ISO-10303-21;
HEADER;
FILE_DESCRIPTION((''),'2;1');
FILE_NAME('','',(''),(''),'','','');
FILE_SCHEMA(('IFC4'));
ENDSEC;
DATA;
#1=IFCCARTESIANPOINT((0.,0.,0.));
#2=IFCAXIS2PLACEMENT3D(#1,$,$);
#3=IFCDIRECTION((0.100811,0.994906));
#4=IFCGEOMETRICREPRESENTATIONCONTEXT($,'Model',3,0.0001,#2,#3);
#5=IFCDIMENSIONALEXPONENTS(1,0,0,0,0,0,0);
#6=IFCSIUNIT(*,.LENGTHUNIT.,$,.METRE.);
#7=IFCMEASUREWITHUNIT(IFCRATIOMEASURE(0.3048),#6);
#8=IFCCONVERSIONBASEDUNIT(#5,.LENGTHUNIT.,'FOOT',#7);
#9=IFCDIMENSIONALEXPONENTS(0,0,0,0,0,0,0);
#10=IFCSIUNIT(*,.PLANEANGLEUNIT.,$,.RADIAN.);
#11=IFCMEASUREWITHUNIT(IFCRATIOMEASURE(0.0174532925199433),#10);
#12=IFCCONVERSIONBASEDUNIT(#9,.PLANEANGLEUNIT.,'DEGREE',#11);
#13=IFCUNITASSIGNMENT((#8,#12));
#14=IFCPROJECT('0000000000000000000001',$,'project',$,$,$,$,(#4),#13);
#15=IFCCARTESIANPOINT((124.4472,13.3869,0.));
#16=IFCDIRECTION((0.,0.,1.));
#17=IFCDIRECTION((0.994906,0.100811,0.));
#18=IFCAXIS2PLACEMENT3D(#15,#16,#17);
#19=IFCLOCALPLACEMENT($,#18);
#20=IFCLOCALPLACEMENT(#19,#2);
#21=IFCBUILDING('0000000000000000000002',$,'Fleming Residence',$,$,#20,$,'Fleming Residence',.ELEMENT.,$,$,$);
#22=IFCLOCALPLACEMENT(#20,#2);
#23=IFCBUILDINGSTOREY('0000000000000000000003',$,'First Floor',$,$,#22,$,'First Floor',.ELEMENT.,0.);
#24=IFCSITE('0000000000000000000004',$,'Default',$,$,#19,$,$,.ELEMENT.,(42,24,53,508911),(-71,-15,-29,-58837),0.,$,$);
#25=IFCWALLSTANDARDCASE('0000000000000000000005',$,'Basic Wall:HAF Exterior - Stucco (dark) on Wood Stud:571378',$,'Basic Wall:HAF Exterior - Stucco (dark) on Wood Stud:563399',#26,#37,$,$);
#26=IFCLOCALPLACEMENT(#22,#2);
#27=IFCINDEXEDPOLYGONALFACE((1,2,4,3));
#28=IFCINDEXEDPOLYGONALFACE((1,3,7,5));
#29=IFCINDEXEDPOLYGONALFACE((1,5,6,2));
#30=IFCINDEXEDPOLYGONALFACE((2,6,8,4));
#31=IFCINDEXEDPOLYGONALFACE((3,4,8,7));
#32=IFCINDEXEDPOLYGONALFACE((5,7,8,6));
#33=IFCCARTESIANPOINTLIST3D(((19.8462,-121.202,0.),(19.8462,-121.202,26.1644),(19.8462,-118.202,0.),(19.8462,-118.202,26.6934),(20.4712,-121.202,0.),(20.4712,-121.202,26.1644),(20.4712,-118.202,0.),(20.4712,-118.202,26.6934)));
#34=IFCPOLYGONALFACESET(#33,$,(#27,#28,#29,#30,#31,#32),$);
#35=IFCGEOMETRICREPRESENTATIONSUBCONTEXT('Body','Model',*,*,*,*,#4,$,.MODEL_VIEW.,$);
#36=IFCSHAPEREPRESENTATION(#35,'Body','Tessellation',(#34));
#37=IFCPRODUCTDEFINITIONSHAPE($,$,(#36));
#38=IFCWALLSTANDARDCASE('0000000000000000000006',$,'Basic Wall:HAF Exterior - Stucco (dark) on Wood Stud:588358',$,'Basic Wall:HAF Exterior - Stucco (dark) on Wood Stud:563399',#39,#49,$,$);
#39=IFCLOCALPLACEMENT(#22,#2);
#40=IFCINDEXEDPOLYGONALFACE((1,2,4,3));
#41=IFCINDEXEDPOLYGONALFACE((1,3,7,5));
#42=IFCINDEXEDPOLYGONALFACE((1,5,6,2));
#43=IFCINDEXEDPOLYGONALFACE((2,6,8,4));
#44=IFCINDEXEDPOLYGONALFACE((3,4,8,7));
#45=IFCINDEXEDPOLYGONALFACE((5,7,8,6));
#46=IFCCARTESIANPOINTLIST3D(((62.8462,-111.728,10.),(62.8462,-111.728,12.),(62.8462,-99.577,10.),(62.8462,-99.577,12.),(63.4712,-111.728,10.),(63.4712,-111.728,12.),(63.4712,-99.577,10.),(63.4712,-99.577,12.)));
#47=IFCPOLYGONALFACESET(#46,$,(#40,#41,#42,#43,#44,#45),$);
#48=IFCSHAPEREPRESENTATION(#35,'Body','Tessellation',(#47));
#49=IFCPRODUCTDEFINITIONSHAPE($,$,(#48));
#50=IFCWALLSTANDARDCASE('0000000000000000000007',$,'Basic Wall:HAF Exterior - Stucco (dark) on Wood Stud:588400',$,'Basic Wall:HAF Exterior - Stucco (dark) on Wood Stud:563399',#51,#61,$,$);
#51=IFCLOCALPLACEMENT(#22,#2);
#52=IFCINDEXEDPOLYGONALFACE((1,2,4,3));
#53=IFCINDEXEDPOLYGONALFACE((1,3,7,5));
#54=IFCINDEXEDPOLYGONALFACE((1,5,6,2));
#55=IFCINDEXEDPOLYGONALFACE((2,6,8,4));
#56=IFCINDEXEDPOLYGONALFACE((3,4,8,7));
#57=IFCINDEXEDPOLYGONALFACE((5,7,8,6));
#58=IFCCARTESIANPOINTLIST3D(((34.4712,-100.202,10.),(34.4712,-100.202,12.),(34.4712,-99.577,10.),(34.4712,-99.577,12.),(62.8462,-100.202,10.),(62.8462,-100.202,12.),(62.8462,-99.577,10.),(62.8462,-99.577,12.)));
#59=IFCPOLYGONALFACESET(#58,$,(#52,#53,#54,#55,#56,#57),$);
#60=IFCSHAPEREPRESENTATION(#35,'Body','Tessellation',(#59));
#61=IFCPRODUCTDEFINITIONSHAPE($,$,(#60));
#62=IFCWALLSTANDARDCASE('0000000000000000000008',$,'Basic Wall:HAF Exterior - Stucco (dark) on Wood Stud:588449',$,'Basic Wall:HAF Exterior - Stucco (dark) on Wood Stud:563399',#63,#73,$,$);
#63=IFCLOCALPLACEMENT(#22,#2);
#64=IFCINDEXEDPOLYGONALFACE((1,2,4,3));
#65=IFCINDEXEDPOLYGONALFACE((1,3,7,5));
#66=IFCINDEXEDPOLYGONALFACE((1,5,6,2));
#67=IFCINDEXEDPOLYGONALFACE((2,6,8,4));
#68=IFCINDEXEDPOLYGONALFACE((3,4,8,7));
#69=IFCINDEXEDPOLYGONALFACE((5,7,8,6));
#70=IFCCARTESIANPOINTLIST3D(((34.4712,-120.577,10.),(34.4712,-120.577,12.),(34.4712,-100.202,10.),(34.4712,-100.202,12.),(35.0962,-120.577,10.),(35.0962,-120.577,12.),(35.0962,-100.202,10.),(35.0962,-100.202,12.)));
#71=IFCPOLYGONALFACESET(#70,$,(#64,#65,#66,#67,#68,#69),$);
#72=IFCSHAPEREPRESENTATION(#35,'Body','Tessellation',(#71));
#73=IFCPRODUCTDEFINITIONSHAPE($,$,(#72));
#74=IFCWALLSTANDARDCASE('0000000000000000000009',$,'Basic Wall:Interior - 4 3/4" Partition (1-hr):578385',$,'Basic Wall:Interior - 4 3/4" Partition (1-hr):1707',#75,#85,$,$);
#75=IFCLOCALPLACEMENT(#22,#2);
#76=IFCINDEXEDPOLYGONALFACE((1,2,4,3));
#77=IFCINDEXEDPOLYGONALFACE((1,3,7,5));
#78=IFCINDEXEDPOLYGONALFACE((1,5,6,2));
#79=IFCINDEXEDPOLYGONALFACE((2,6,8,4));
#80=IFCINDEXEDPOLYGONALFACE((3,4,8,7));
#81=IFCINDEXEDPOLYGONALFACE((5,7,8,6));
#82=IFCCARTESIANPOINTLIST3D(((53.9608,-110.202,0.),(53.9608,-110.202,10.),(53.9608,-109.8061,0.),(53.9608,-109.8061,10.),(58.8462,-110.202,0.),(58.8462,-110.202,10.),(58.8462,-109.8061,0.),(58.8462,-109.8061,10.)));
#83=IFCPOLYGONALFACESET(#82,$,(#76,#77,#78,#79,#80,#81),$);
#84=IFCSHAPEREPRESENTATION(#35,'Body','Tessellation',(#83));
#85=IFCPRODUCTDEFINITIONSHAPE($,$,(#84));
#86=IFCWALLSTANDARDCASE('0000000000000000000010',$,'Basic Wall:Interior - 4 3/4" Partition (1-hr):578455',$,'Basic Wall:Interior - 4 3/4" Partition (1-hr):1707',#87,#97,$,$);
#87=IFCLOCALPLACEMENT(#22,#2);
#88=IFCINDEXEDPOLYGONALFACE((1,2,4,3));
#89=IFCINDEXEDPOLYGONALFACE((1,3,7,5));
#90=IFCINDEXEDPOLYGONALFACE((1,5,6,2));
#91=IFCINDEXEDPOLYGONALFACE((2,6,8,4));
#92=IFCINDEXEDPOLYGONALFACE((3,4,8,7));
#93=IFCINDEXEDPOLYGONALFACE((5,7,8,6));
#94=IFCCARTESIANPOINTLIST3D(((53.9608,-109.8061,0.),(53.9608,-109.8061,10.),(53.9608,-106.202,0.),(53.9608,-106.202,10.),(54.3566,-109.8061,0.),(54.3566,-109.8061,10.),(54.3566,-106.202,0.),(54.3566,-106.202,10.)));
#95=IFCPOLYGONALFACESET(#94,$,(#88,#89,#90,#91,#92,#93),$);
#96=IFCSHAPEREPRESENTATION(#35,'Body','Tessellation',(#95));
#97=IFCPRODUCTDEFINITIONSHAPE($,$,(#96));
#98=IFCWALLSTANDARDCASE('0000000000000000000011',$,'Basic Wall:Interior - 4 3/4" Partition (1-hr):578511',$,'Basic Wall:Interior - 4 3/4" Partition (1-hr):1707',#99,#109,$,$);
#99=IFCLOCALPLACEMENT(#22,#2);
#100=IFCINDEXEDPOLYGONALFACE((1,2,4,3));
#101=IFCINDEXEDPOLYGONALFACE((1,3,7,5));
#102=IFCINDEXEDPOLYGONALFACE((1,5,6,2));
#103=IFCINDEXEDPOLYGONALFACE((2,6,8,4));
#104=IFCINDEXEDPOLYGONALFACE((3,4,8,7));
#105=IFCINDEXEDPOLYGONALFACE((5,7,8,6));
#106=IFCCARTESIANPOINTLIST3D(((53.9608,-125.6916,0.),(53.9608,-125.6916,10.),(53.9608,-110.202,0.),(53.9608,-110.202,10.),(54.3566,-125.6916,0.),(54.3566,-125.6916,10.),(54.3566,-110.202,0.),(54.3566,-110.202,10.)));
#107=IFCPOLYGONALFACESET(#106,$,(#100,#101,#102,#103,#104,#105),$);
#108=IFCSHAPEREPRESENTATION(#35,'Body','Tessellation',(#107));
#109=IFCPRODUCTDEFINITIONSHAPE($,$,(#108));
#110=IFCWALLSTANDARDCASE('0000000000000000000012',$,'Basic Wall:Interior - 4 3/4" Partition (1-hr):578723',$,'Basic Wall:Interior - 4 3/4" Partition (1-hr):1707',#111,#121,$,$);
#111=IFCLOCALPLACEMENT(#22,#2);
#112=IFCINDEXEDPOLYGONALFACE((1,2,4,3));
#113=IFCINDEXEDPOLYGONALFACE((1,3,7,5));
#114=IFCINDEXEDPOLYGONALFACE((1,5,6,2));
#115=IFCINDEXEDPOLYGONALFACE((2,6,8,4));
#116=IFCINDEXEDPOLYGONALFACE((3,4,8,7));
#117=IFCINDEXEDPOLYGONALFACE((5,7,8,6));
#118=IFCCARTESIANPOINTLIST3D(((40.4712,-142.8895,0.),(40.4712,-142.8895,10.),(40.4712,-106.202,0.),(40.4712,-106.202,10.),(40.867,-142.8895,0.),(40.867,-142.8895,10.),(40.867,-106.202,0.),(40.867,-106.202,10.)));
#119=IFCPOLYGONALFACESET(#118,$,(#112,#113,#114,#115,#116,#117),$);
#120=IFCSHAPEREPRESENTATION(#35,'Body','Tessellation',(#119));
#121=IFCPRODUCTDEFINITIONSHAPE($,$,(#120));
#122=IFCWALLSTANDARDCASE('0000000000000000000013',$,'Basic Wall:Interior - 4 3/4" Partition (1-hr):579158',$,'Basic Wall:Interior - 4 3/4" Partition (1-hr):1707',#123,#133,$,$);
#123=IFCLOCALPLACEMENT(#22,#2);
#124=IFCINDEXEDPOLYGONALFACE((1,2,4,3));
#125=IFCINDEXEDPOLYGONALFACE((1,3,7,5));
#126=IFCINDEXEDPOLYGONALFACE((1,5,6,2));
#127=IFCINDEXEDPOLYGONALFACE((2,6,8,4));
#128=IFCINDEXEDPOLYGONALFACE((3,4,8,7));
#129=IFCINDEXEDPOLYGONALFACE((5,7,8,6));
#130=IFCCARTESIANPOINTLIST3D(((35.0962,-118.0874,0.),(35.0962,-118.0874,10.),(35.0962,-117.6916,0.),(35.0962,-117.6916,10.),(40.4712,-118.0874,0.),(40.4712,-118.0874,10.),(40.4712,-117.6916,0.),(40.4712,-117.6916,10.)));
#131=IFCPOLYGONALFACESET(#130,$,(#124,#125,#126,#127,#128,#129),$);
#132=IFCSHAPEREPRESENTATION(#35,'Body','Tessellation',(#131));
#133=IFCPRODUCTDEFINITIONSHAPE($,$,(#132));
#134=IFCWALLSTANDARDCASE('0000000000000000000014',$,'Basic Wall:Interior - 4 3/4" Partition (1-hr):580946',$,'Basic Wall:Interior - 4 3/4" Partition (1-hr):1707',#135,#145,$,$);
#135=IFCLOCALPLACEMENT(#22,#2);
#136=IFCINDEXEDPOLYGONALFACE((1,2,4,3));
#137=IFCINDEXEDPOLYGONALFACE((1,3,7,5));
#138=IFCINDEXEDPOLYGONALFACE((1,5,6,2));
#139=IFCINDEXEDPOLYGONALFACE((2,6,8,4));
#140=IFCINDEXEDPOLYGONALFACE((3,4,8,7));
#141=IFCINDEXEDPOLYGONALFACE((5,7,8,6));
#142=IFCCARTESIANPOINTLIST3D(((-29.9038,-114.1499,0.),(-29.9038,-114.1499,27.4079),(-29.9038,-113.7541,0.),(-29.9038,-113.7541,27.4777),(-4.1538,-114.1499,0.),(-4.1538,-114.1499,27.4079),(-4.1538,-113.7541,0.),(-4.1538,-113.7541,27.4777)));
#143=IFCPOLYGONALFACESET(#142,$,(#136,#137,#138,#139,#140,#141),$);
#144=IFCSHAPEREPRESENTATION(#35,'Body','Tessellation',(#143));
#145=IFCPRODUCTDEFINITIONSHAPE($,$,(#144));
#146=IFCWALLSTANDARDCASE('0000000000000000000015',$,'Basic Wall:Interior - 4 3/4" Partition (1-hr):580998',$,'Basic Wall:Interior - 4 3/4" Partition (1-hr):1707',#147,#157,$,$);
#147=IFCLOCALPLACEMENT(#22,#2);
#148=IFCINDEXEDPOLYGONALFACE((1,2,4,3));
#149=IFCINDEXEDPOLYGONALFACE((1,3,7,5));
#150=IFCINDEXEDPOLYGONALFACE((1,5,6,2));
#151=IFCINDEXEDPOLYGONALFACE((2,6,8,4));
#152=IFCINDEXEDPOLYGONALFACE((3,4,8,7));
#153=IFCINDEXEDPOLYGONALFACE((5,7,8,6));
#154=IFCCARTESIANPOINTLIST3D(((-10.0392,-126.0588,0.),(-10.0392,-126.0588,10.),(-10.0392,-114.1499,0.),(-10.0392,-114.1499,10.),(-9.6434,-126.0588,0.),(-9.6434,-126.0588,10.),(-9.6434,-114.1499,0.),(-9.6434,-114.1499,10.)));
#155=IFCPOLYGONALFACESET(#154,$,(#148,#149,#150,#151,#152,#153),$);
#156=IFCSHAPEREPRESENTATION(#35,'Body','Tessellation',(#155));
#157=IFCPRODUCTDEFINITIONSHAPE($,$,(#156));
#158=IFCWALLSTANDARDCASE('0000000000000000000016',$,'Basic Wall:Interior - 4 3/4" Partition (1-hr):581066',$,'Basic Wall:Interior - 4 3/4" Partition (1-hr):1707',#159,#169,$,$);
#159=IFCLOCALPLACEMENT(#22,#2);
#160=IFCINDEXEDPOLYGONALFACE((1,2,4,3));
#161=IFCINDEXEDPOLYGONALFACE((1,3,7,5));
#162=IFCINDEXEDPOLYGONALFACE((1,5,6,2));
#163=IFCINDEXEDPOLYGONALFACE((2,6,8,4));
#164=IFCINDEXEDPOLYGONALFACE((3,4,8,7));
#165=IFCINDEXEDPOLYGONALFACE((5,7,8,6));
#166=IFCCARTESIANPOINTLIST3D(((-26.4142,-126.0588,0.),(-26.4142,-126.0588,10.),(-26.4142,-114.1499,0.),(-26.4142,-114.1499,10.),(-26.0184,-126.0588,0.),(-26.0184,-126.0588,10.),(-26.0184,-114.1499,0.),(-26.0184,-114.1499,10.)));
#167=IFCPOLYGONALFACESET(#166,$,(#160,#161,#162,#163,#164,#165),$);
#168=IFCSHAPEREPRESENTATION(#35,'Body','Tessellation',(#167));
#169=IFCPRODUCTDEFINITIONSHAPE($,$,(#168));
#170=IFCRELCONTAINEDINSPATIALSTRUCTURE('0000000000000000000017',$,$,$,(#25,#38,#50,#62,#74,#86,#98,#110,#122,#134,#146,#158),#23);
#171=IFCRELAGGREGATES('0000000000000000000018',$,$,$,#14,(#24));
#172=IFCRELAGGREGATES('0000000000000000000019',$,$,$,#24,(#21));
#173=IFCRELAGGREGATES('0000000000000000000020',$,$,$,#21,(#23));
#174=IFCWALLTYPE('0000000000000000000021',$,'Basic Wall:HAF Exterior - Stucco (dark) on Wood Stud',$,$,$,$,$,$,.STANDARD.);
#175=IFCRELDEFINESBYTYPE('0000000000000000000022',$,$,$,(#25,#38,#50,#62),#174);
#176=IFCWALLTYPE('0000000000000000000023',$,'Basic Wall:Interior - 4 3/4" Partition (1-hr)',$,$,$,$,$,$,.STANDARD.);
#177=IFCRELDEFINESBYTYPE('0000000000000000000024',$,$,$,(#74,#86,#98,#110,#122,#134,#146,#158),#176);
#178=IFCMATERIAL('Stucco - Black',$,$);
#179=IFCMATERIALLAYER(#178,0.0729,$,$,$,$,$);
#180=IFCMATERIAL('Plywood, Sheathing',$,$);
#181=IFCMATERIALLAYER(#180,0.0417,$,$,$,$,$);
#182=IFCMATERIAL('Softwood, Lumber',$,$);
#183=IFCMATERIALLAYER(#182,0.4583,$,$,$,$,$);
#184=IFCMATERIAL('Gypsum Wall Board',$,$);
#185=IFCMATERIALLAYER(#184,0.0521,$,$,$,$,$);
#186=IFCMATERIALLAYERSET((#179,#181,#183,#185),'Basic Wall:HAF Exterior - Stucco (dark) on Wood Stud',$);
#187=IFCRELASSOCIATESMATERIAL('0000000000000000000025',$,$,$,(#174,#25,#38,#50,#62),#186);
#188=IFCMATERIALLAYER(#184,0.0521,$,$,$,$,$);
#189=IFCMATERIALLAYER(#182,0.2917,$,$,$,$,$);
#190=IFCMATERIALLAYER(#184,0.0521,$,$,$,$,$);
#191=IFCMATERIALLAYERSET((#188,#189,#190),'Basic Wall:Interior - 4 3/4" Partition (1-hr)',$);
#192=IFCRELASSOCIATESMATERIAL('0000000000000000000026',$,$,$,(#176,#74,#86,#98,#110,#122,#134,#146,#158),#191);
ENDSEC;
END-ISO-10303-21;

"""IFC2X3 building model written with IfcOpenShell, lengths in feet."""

from ifc_helpers import new_model, entity, si_unit, converted_unit, direction, frame, frame_2d, origin, place, context, subcontext, project, spatial, polyline, rectangle, extrude, clip, bounded_halfspace, material, layer, layer_set, layer_usage, type_object, element, save


model = new_model("IFC2X3")

# Units and contexts
model_context = context("Model", 3, precision=0.0001, world=origin(), true_north=direction((0.100811, 0.994906)))
body_context = subcontext(model_context, "Body", "Model", "MODEL_VIEW")
ifc_project = project(units=[converted_unit("LENGTHUNIT", "FOOT", entity("IfcRatioMeasure", 0.3048), si_unit("LENGTHUNIT", "METRE"), dimensions=[1, 0, 0, 0, 0, 0, 0]), converted_unit("PLANEANGLEUNIT", "DEGREE", entity("IfcRatioMeasure", 0.0174532925199433), si_unit("PLANEANGLEUNIT", "RADIAN"), dimensions=[0, 0, 0, 0, 0, 0, 0])], contexts=[model_context])

# Site, building, storey
site_placement = place(None, frame((124.4472, 13.3869, 0.0), z_axis=(0.0, 0.0, 1.0), x_axis=(0.994906, 0.100811, 0.0)))
site = spatial("IfcSite", under=ifc_project, at=site_placement, Name="Default", CompositionType="ELEMENT", RefLatitude=(42, 24, 53, 508911), RefLongitude=(-71, -15, -29, -58837), RefElevation=0.0)
building_placement = place(site_placement, origin())
building = spatial("IfcBuilding", under=site, at=building_placement, Name="Fleming Residence", LongName="Fleming Residence", CompositionType="ELEMENT")
storey_placement = place(building_placement, origin())
storey = spatial("IfcBuildingStorey", under=building, at=storey_placement, Name="First Floor", LongName="First Floor", CompositionType="ELEMENT", Elevation=0.0)

# Walls
ifc_material_1 = material(Name="Plywood, Sheathing")
ifc_material_2 = material(Name="Softwood, Lumber")
ifc_material_3 = material(Name="Gypsum Wall Board")
ifc_material_4 = material(Name="Stucco - Black")
ifc_layer_1 = layer(ifc_material_4, 0.0729)
ifc_layer_2 = layer(ifc_material_1, 0.0417)
ifc_layer_3 = layer(ifc_material_2, 0.4583)
ifc_layer_4 = layer(ifc_material_3, 0.0521)
ifc_layer_set_1 = layer_set([ifc_layer_1, ifc_layer_2, ifc_layer_3, ifc_layer_4], Name="Basic Wall:HAF Exterior - Stucco (dark) on Wood Stud")
ifc_layer_usage_1 = layer_usage(ifc_layer_set_1, "AXIS2", "NEGATIVE", 0.3125)
wall_type_1 = type_object("IfcWallType", Name="Basic Wall:HAF Exterior - Stucco (dark) on Wood Stud", PredefinedType="STANDARD", material=ifc_layer_set_1)
wall_1_placement = place(storey_placement, frame((20.1587, -118.202, 0.0), z_axis=(0.0, 0.0, 1.0), x_axis=(0.0, -1.0, 0.0)))
element("IfcWallStandardCase", 1, at=wall_1_placement, inside=storey, type_object=wall_type_1, material=ifc_layer_usage_1, Name="Basic Wall:HAF Exterior - Stucco (dark) on Wood Stud:571378", ObjectType="Basic Wall:HAF Exterior - Stucco (dark) on Wood Stud:563399", context=body_context, shape_type="Clipping", body=[
    clip(extrude(rectangle(XDim=3.0, YDim=0.625, at=frame_2d((1.5, 0.0), x_axis=(-1.0, 0.0))), origin(), (0.0, 0.0, 1.0), 26.6934), bounded_halfspace(frame((0.0, -0.3125, 26.6934), z_axis=(-0.173648, 0.0, -0.984808), x_axis=(0.0, -1.0, 0.0)), True, frame((0.0, -0.3125, 26.6934)), polyline([(0.0, 0.0), (3.0, 0.0), (3.0, 0.625), (2.375, 0.625), (0.0, 0.625), (0.0, 0.0)]))),
])
ifc_layer_usage_2 = layer_usage(ifc_layer_set_1, "AXIS2", "POSITIVE", -0.3125)
wall_2_placement = place(storey_placement, frame((63.1587, -111.728, 10.0), z_axis=(0.0, 0.0, 1.0), x_axis=(0.0, 1.0, 0.0)))
element("IfcWallStandardCase", 2, at=wall_2_placement, inside=storey, type_object=wall_type_1, material=ifc_layer_usage_2, Name="Basic Wall:HAF Exterior - Stucco (dark) on Wood Stud:588358", ObjectType="Basic Wall:HAF Exterior - Stucco (dark) on Wood Stud:563399", context=body_context, shape_type="SweptSolid", body=[
    extrude(rectangle(XDim=12.151, YDim=0.625, at=frame_2d((6.0755, 0.0), x_axis=(-1.0, 0.0))), origin(), (0.0, 0.0, 1.0), 2.0),
])
ifc_layer_usage_3 = layer_usage(ifc_layer_set_1, "AXIS2", "POSITIVE", -0.3125)
wall_3_placement = place(storey_placement, frame((62.8462, -99.8895, 10.0), z_axis=(0.0, 0.0, 1.0), x_axis=(-1.0, 0.0, 0.0)))
element("IfcWallStandardCase", 3, at=wall_3_placement, inside=storey, type_object=wall_type_1, material=ifc_layer_usage_3, Name="Basic Wall:HAF Exterior - Stucco (dark) on Wood Stud:588400", ObjectType="Basic Wall:HAF Exterior - Stucco (dark) on Wood Stud:563399", context=body_context, shape_type="SweptSolid", body=[
    extrude(rectangle(XDim=28.375, YDim=0.625, at=frame_2d((14.1875, 0.0), x_axis=(-1.0, 0.0))), origin(), (0.0, 0.0, 1.0), 2.0),
])
ifc_layer_usage_4 = layer_usage(ifc_layer_set_1, "AXIS2", "POSITIVE", -0.3125)
wall_4_placement = place(storey_placement, frame((34.7837, -100.202, 10.0), z_axis=(0.0, 0.0, 1.0), x_axis=(0.0, -1.0, 0.0)))
element("IfcWallStandardCase", 4, at=wall_4_placement, inside=storey, type_object=wall_type_1, material=ifc_layer_usage_4, Name="Basic Wall:HAF Exterior - Stucco (dark) on Wood Stud:588449", ObjectType="Basic Wall:HAF Exterior - Stucco (dark) on Wood Stud:563399", context=body_context, shape_type="SweptSolid", body=[
    extrude(rectangle(XDim=20.375, YDim=0.625, at=frame_2d((10.1875, 0.0), x_axis=(-1.0, 0.0))), origin(), (0.0, 0.0, 1.0), 2.0),
])
ifc_layer_5 = layer(ifc_material_3, 0.0521)
ifc_layer_6 = layer(ifc_material_2, 0.2917)
ifc_layer_7 = layer(ifc_material_3, 0.0521)
ifc_layer_set_2 = layer_set([ifc_layer_5, ifc_layer_6, ifc_layer_7], Name="Basic Wall:Interior - 4 3/4\" Partition (1-hr)")
ifc_layer_usage_5 = layer_usage(ifc_layer_set_2, "AXIS2", "NEGATIVE", 0.1979)
wall_type_2 = type_object("IfcWallType", Name="Basic Wall:Interior - 4 3/4\" Partition (1-hr)", PredefinedType="STANDARD", material=ifc_layer_set_2)
wall_5_placement = place(storey_placement, frame((58.8462, -110.0041, 0.0), z_axis=(0.0, 0.0, 1.0), x_axis=(-1.0, 0.0, 0.0)))
element("IfcWallStandardCase", 5, at=wall_5_placement, inside=storey, type_object=wall_type_2, material=ifc_layer_usage_5, Name="Basic Wall:Interior - 4 3/4\" Partition (1-hr):578385", ObjectType="Basic Wall:Interior - 4 3/4\" Partition (1-hr):1707", context=body_context, shape_type="SweptSolid", body=[
    extrude(rectangle(XDim=4.8854, YDim=0.3958, at=frame_2d((2.4427, 0.0), x_axis=(-1.0, 0.0))), origin(), (0.0, 0.0, 1.0), 10.0),
])
ifc_layer_usage_6 = layer_usage(ifc_layer_set_2, "AXIS2", "NEGATIVE", 0.1979)
wall_6_placement = place(storey_placement, frame((54.1587, -109.8061, 0.0), z_axis=(0.0, 0.0, 1.0), x_axis=(0.0, 1.0, 0.0)))
element("IfcWallStandardCase", 6, at=wall_6_placement, inside=storey, type_object=wall_type_2, material=ifc_layer_usage_6, Name="Basic Wall:Interior - 4 3/4\" Partition (1-hr):578455", ObjectType="Basic Wall:Interior - 4 3/4\" Partition (1-hr):1707", context=body_context, shape_type="SweptSolid", body=[
    extrude(rectangle(XDim=3.6042, YDim=0.3958, at=frame_2d((1.8021, 0.0), x_axis=(-1.0, 0.0))), origin(), (0.0, 0.0, 1.0), 10.0),
])
ifc_layer_usage_7 = layer_usage(ifc_layer_set_2, "AXIS2", "NEGATIVE", 0.1979)
wall_7_placement = place(storey_placement, frame((54.1587, -110.202, 0.0), z_axis=(0.0, 0.0, 1.0), x_axis=(0.0, -1.0, 0.0)))
element("IfcWallStandardCase", 7, at=wall_7_placement, inside=storey, type_object=wall_type_2, material=ifc_layer_usage_7, Name="Basic Wall:Interior - 4 3/4\" Partition (1-hr):578511", ObjectType="Basic Wall:Interior - 4 3/4\" Partition (1-hr):1707", context=body_context, shape_type="SweptSolid", body=[
    extrude(rectangle(XDim=15.4896, YDim=0.3958, at=frame_2d((7.7448, 0.0), x_axis=(-1.0, 0.0))), origin(), (0.0, 0.0, 1.0), 10.0),
])
ifc_layer_usage_8 = layer_usage(ifc_layer_set_2, "AXIS2", "NEGATIVE", 0.1979)
wall_8_placement = place(storey_placement, frame((40.6691, -106.202, 0.0), z_axis=(0.0, 0.0, 1.0), x_axis=(0.0, -1.0, 0.0)))
element("IfcWallStandardCase", 8, at=wall_8_placement, inside=storey, type_object=wall_type_2, material=ifc_layer_usage_8, Name="Basic Wall:Interior - 4 3/4\" Partition (1-hr):578723", ObjectType="Basic Wall:Interior - 4 3/4\" Partition (1-hr):1707", context=body_context, shape_type="SweptSolid", body=[
    extrude(rectangle(XDim=36.6875, YDim=0.3958, at=frame_2d((18.3438, 0.0), x_axis=(-1.0, 0.0))), origin(), (0.0, 0.0, 1.0), 10.0),
])
ifc_layer_usage_9 = layer_usage(ifc_layer_set_2, "AXIS2", "NEGATIVE", 0.1979)
wall_9_placement = place(storey_placement, frame((40.4712, -117.8895, 0.0), z_axis=(0.0, 0.0, 1.0), x_axis=(-1.0, 0.0, 0.0)))
element("IfcWallStandardCase", 9, at=wall_9_placement, inside=storey, type_object=wall_type_2, material=ifc_layer_usage_9, Name="Basic Wall:Interior - 4 3/4\" Partition (1-hr):579158", ObjectType="Basic Wall:Interior - 4 3/4\" Partition (1-hr):1707", context=body_context, shape_type="SweptSolid", body=[
    extrude(rectangle(XDim=5.375, YDim=0.3958, at=frame_2d((2.6875, 0.0), x_axis=(-1.0, 0.0))), origin(), (0.0, 0.0, 1.0), 10.0),
])
ifc_layer_usage_10 = layer_usage(ifc_layer_set_2, "AXIS2", "NEGATIVE", 0.1979)
wall_10_placement = place(storey_placement, frame((-4.1538, -113.952, 0.0), z_axis=(0.0, 0.0, 1.0), x_axis=(-1.0, 0.0, 0.0)))
element("IfcWallStandardCase", 10, at=wall_10_placement, inside=storey, type_object=wall_type_2, material=ifc_layer_usage_10, Name="Basic Wall:Interior - 4 3/4\" Partition (1-hr):580946", ObjectType="Basic Wall:Interior - 4 3/4\" Partition (1-hr):1707", context=body_context, shape_type="Clipping", body=[
    clip(extrude(rectangle(XDim=25.75, YDim=0.3958, at=frame_2d((12.875, 0.0), x_axis=(-1.0, 0.0))), origin(), (0.0, 0.0, 1.0), 27.4777), bounded_halfspace(frame((0.0, -0.1979, 27.4777), z_axis=(0.0, -0.173648, -0.984808), x_axis=(1.0, 0.0, 0.0)), True, frame((0.0, -0.1979, 27.4777)), polyline([(0.0, 0.0), (25.75, 0.0), (25.75, 0.3958), (0.0, 0.3958), (0.0, 0.3354), (0.0, 0.0)]))),
])
ifc_layer_usage_11 = layer_usage(ifc_layer_set_2, "AXIS2", "NEGATIVE", 0.1979)
wall_11_placement = place(storey_placement, frame((-9.8413, -114.1499, 0.0), z_axis=(0.0, 0.0, 1.0), x_axis=(0.0, -1.0, 0.0)))
element("IfcWallStandardCase", 11, at=wall_11_placement, inside=storey, type_object=wall_type_2, material=ifc_layer_usage_11, Name="Basic Wall:Interior - 4 3/4\" Partition (1-hr):580998", ObjectType="Basic Wall:Interior - 4 3/4\" Partition (1-hr):1707", context=body_context, shape_type="SweptSolid", body=[
    extrude(rectangle(XDim=11.9089, YDim=0.3958, at=frame_2d((5.9544, 0.0), x_axis=(-1.0, 0.0))), origin(), (0.0, 0.0, 1.0), 10.0),
])
ifc_layer_usage_12 = layer_usage(ifc_layer_set_2, "AXIS2", "NEGATIVE", 0.1979)
wall_12_placement = place(storey_placement, frame((-26.2163, -114.1499, 0.0), z_axis=(0.0, 0.0, 1.0), x_axis=(0.0, -1.0, 0.0)))
element("IfcWallStandardCase", 12, at=wall_12_placement, inside=storey, type_object=wall_type_2, material=ifc_layer_usage_12, Name="Basic Wall:Interior - 4 3/4\" Partition (1-hr):581066", ObjectType="Basic Wall:Interior - 4 3/4\" Partition (1-hr):1707", context=body_context, shape_type="SweptSolid", body=[
    extrude(rectangle(XDim=11.9089, YDim=0.3958, at=frame_2d((5.9544, 0.0), x_axis=(-1.0, 0.0))), origin(), (0.0, 0.0, 1.0), 10.0),
])

save(model, "model.ifc")
